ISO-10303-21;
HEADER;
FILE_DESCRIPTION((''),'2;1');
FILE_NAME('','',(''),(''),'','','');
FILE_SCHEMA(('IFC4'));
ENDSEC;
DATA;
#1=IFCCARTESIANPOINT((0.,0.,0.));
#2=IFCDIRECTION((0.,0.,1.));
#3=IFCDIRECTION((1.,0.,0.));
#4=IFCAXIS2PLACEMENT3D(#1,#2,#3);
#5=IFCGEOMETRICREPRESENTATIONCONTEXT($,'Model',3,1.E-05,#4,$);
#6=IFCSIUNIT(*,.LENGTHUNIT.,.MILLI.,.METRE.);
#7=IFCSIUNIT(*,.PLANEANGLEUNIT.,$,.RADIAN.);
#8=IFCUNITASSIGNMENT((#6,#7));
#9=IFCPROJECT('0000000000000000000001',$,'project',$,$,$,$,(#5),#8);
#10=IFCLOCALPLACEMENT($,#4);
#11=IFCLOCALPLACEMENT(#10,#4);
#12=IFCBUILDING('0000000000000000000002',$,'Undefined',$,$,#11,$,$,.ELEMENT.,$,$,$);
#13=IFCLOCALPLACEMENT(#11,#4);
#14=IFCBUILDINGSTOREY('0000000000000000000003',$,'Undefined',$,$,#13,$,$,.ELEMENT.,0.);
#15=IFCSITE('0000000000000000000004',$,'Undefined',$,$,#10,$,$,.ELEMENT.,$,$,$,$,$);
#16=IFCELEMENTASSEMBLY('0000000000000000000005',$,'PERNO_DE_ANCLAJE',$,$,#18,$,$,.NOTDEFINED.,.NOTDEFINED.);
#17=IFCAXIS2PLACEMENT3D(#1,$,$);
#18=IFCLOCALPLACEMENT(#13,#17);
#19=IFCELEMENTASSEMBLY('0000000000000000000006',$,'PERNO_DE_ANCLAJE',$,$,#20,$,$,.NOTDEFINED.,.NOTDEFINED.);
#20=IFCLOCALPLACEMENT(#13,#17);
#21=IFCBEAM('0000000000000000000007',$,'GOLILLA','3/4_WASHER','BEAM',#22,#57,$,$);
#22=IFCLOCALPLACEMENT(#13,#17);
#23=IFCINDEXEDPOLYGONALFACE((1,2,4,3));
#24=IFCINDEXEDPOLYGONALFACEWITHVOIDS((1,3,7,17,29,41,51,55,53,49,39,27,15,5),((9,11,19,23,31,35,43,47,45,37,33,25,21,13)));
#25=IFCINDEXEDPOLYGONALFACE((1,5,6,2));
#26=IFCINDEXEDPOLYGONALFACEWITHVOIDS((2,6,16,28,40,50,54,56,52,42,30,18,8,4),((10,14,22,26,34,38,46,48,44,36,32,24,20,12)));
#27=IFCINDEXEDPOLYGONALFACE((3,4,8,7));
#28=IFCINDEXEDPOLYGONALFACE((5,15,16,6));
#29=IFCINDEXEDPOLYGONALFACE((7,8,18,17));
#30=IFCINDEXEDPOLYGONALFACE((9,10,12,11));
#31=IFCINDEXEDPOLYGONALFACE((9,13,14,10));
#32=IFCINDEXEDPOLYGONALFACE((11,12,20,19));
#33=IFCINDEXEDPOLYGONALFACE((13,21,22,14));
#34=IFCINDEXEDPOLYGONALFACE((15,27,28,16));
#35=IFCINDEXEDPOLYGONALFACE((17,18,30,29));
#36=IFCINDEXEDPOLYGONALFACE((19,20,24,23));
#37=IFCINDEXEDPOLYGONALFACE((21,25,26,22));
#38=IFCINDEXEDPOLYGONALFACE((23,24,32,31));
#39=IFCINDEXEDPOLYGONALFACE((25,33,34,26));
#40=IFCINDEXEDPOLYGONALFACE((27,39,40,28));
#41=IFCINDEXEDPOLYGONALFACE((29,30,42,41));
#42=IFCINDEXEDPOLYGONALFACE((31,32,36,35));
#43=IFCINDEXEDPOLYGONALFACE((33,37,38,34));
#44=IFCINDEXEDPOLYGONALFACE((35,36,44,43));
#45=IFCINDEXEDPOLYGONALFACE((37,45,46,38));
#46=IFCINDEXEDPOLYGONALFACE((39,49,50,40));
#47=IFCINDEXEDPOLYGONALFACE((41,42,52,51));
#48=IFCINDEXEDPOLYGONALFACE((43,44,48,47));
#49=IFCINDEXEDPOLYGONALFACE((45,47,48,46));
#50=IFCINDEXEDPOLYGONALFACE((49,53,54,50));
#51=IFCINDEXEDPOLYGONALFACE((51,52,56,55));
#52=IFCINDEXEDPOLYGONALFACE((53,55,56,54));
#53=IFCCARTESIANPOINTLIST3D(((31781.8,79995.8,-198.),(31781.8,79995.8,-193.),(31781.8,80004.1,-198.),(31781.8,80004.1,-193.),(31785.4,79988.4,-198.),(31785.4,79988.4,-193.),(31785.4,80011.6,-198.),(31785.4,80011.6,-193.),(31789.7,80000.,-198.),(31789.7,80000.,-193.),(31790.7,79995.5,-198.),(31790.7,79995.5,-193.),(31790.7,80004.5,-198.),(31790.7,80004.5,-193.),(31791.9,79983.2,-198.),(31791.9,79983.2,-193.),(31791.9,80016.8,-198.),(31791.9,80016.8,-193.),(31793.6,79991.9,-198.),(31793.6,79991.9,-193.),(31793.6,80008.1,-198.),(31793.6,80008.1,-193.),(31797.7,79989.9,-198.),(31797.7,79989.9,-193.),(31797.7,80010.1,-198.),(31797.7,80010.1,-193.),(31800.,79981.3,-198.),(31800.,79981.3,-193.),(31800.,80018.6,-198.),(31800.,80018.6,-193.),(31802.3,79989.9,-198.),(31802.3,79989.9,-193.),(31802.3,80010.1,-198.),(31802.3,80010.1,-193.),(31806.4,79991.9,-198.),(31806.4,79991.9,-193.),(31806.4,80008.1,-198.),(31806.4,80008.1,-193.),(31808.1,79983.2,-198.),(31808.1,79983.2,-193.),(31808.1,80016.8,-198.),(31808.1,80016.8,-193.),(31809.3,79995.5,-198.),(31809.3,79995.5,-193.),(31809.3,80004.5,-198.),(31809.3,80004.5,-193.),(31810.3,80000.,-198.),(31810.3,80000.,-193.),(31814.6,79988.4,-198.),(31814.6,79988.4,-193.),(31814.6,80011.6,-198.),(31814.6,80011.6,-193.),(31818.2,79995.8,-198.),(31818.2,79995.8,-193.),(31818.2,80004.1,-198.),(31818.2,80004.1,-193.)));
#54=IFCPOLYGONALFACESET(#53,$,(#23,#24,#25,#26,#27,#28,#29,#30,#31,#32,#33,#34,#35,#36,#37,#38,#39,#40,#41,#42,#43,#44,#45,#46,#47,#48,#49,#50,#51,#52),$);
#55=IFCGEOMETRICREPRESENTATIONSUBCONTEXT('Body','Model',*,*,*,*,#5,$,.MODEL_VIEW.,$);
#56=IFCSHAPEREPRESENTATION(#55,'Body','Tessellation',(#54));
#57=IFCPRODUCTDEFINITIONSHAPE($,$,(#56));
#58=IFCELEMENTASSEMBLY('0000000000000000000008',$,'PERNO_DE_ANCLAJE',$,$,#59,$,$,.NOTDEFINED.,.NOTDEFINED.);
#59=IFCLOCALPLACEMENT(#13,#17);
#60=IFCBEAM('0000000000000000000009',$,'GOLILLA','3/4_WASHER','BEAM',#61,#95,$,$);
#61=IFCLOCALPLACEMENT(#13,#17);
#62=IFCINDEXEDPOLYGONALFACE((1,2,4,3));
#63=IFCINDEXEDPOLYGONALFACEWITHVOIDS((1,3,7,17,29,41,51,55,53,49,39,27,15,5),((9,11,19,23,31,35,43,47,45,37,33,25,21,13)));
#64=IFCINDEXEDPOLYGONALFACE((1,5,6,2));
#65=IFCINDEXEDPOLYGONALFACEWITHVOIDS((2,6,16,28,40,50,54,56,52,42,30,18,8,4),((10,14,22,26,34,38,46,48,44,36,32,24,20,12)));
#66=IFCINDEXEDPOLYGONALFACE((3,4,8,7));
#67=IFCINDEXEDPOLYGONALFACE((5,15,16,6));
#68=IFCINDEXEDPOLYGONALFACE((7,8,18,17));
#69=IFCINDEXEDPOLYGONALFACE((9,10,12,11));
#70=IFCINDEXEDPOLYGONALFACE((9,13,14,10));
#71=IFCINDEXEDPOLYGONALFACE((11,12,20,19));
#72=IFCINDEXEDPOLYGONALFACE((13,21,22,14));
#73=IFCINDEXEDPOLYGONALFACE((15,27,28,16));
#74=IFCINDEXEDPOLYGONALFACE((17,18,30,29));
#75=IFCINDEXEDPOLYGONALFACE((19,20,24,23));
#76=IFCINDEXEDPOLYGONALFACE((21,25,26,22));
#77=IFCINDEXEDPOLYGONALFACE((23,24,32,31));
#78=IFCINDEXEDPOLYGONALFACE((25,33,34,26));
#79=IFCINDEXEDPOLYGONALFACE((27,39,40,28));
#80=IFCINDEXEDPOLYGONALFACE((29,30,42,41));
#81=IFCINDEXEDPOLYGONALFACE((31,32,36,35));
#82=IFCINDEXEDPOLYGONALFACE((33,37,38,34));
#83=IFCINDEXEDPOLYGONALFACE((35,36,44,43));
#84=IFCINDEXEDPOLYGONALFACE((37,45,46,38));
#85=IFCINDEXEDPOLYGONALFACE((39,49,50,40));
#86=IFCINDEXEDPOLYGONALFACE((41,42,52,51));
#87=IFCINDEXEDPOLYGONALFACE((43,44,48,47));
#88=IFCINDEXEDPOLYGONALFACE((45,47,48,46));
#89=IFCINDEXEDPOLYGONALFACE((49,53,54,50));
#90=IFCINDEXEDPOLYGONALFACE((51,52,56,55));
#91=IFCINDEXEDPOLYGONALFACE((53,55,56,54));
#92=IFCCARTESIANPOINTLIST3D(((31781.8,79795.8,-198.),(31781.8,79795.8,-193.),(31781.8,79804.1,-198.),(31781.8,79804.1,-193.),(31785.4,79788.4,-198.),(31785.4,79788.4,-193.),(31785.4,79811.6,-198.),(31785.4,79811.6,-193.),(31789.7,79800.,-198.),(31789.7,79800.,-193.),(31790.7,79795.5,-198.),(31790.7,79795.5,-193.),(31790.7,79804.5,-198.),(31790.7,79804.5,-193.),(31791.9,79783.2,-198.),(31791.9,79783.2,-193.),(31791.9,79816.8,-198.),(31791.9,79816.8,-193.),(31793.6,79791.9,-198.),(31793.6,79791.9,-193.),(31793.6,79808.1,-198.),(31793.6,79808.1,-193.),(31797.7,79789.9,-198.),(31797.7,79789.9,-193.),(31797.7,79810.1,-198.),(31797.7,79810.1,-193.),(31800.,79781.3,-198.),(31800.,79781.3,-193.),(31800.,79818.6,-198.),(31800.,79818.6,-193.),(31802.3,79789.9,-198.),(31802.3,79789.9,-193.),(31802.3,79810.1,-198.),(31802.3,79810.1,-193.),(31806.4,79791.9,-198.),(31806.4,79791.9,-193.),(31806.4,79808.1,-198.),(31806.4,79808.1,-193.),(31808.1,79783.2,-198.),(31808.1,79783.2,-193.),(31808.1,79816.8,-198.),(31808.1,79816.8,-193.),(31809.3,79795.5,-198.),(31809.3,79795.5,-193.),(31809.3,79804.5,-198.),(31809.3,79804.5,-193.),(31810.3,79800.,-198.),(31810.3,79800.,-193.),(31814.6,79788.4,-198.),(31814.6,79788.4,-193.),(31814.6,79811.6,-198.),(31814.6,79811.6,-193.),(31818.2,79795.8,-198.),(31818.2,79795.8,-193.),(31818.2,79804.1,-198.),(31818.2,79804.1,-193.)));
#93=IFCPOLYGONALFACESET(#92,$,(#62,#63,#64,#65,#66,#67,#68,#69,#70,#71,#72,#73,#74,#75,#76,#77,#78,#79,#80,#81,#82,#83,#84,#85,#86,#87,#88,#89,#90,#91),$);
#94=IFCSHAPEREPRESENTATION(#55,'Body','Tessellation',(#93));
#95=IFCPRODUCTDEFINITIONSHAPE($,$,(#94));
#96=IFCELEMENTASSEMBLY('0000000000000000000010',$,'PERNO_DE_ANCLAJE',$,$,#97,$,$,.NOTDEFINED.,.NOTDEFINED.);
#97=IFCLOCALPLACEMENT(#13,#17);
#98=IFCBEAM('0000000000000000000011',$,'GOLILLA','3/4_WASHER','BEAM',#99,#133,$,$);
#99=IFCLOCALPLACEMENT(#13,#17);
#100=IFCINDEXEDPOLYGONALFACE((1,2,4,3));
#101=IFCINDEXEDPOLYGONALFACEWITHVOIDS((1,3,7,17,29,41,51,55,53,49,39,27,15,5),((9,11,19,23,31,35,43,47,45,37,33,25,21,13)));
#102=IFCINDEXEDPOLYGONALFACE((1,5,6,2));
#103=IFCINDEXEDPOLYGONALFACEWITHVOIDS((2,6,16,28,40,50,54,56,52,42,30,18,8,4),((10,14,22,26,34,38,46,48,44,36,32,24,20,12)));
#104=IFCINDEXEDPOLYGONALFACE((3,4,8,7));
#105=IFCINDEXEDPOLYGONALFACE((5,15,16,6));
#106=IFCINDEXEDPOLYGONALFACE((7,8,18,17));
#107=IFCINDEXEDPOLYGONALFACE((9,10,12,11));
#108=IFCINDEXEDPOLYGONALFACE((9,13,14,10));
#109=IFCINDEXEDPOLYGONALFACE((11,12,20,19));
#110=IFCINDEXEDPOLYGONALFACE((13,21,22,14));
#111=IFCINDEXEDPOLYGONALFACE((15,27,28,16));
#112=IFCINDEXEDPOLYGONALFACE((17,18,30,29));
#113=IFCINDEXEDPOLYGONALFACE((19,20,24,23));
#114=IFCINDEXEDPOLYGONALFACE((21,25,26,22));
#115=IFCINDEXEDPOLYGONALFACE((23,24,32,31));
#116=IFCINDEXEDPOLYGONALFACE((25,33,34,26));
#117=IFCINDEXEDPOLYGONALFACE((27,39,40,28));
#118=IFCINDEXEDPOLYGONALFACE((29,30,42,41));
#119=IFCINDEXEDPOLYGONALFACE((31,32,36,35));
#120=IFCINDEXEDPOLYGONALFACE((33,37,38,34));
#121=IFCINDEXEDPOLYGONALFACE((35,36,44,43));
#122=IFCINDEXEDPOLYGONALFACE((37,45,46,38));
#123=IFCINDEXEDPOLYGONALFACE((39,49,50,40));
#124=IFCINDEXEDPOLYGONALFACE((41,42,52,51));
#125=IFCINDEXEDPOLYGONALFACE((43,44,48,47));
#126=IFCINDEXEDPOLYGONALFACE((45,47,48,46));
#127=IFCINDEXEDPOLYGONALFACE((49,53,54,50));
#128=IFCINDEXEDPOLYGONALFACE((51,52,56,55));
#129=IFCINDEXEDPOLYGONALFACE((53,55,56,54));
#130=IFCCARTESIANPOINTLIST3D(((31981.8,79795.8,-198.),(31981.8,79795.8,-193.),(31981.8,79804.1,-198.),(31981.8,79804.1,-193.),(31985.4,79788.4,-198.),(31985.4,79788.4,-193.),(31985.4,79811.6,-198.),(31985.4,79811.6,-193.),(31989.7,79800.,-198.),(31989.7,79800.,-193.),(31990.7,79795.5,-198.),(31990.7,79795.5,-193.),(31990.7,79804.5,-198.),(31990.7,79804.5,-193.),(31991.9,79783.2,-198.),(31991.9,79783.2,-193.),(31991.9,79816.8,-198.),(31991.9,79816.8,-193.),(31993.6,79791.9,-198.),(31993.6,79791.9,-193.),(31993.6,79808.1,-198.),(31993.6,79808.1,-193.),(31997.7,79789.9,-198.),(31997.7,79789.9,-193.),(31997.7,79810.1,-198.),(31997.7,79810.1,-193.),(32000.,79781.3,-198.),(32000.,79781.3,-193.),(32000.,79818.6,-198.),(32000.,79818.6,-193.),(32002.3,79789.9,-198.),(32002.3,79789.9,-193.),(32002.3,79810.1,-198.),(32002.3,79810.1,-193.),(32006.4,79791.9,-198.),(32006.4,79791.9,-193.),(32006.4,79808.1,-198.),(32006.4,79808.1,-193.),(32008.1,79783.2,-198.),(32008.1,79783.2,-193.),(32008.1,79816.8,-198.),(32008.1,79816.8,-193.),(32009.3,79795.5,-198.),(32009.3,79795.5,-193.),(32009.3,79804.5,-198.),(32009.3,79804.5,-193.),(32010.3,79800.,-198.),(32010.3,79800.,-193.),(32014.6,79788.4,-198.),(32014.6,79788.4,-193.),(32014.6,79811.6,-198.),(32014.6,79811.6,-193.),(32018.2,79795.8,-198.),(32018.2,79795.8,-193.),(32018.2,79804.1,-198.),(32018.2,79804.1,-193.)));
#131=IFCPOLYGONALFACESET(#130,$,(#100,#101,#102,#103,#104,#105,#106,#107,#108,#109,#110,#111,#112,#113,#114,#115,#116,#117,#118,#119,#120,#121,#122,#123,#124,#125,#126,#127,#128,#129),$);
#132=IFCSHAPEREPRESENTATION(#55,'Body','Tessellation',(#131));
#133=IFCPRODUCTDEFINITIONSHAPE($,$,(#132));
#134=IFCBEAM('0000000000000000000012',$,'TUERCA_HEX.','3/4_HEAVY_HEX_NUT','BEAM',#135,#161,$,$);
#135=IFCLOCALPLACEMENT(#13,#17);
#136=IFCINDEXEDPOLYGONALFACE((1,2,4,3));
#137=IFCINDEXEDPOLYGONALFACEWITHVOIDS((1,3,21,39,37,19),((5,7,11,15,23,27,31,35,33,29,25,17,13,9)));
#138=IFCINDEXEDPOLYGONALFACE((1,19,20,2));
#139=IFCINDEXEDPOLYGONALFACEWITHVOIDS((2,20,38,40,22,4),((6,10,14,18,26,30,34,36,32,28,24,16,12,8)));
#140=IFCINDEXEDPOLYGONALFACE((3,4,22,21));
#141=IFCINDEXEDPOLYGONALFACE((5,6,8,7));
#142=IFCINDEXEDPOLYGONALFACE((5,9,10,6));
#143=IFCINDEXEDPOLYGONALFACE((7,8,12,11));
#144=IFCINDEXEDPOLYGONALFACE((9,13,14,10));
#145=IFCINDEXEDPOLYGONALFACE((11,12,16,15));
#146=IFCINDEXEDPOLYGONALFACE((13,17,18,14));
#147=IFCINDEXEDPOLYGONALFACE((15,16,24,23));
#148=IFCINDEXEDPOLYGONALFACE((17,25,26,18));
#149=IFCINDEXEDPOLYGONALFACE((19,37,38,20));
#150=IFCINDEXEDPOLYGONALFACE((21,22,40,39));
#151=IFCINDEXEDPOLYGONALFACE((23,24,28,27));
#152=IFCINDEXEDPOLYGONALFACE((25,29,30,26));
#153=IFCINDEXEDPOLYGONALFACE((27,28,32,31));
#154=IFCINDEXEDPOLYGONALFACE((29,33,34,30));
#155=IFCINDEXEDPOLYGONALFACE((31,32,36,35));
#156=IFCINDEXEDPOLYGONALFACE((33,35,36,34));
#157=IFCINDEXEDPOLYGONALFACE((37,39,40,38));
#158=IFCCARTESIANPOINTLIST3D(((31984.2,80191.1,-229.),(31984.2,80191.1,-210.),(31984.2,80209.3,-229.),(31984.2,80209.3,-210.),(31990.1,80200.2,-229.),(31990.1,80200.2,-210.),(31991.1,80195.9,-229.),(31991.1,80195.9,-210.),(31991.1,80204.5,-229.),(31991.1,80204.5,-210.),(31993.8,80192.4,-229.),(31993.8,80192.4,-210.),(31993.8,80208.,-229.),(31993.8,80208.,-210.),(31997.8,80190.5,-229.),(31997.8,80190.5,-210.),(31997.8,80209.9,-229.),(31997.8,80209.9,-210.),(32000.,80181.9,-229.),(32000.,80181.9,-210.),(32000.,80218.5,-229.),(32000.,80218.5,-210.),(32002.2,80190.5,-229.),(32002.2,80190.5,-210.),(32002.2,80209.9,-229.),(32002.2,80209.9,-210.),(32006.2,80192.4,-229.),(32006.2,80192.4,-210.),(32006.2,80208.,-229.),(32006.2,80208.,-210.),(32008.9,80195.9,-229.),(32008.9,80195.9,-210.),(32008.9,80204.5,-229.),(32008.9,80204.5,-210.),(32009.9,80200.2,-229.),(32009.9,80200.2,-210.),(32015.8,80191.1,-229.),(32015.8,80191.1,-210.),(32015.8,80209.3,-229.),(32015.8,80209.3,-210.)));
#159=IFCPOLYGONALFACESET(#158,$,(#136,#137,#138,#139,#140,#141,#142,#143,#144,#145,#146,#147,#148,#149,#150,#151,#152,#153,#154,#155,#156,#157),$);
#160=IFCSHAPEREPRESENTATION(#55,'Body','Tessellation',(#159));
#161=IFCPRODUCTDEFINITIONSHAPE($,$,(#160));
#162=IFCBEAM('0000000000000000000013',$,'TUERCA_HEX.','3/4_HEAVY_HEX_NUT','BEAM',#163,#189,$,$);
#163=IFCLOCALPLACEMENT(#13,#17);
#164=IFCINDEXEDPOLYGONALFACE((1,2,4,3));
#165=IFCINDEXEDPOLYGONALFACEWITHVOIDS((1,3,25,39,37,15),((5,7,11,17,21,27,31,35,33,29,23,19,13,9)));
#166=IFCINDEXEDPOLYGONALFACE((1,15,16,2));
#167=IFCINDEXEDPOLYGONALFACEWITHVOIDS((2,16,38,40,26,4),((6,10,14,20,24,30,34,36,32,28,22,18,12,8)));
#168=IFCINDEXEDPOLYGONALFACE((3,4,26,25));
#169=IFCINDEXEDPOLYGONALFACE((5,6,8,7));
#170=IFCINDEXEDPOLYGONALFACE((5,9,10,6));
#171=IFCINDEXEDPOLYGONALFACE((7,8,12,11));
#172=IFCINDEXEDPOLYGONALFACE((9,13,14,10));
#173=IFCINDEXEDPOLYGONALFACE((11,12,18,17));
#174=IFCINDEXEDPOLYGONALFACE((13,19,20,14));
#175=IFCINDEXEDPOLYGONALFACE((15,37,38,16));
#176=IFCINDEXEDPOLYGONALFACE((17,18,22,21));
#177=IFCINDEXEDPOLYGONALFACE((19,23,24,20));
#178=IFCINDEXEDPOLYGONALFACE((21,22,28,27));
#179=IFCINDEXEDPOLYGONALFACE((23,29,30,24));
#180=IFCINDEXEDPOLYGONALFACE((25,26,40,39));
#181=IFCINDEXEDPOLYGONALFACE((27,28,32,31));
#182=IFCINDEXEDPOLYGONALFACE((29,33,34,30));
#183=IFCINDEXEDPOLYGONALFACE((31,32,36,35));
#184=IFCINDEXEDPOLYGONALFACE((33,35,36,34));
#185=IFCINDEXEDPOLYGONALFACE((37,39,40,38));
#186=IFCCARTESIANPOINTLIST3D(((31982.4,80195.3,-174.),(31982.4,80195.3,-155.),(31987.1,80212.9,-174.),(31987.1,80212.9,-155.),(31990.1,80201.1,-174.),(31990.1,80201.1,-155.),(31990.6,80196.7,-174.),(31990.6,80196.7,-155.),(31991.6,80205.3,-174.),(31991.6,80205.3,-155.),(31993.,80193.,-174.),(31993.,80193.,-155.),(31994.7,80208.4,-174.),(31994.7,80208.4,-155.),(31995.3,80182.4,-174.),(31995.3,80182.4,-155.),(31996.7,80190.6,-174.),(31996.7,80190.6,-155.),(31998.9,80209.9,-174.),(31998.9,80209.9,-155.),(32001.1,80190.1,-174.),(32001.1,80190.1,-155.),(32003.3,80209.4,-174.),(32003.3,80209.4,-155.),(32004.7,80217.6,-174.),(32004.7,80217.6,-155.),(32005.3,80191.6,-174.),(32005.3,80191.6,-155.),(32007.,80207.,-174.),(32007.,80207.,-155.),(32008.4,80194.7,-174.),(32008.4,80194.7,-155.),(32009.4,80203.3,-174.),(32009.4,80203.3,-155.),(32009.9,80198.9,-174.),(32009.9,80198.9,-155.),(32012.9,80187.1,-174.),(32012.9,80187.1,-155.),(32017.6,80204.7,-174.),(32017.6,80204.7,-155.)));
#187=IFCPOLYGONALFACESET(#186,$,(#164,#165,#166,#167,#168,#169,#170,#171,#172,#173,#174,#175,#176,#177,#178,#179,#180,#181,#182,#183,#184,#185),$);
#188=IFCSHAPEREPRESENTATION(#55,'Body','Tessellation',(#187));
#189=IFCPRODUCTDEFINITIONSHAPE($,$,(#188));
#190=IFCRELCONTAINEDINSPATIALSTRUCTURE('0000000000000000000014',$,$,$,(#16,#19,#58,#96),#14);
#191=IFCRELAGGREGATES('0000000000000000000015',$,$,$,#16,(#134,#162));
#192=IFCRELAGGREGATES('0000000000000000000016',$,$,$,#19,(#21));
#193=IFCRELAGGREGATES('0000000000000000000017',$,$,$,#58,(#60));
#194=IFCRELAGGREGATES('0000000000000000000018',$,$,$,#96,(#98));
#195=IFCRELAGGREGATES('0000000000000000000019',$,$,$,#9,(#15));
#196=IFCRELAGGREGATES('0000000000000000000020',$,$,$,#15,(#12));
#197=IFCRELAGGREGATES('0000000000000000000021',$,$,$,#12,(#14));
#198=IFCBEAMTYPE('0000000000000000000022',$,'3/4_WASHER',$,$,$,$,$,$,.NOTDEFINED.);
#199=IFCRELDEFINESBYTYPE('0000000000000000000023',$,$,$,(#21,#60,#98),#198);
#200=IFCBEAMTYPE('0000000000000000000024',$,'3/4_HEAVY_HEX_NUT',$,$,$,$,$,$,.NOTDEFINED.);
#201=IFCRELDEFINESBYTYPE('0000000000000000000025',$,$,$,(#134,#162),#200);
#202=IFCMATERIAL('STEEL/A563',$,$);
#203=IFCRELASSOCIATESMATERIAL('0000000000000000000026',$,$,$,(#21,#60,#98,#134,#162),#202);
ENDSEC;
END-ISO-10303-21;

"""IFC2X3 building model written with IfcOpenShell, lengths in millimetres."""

from ifc_helpers import new_model, si_unit, frame, origin_with_axes, place, context, subcontext, project, spatial, polyline, outline, extrude, material, type_object, element, aggregate, save


model = new_model("IFC2X3")

# Units and contexts
model_context = context("Model", 3, precision=1e-05, world=origin_with_axes())
body_context = subcontext(model_context, "Body", "Model", "MODEL_VIEW")
ifc_project = project(units=[si_unit("LENGTHUNIT", "METRE", prefix="MILLI"), si_unit("PLANEANGLEUNIT", "RADIAN")], contexts=[model_context])

# Site, building, storey
site_placement = place(None, origin_with_axes())
site = spatial("IfcSite", under=ifc_project, at=site_placement, Name="Undefined", CompositionType="ELEMENT")
building_placement = place(site_placement, origin_with_axes())
building = spatial("IfcBuilding", under=site, at=building_placement, Name="Undefined", CompositionType="ELEMENT")
storey_placement = place(building_placement, origin_with_axes())
storey = spatial("IfcBuildingStorey", under=building, at=storey_placement, Name="Undefined", CompositionType="ELEMENT", Elevation=0.0)

# Element assemblies, beams
assembly_1_placement = place(storey_placement, origin_with_axes())
assembly_1 = element("IfcElementAssembly", 1, at=assembly_1_placement, inside=storey, Name="PERNO_DE_ANCLAJE", AssemblyPlace="NOTDEFINED", PredefinedType="NOTDEFINED")
ifc_material_1 = material(Name="STEEL/A563")
beam_type_1 = type_object("IfcBeamType", Name="3/4_WASHER", PredefinedType="NOTDEFINED")
assembly_2_placement = place(storey_placement, origin_with_axes())
assembly_2 = element("IfcElementAssembly", 2, at=assembly_2_placement, inside=storey, Name="PERNO_DE_ANCLAJE", AssemblyPlace="NOTDEFINED", PredefinedType="NOTDEFINED")
beam_1_placement = place(assembly_2_placement, frame((31800.0, 80000.0, -193.0), z_axis=(1.0, 0.0, 0.0), x_axis=(0.0, 0.00008, -1.0)))
beam_1 = element("IfcBeam", 3, at=beam_1_placement, type_object=beam_type_1, material=ifc_material_1, Name="GOLILLA", Description="3/4_WASHER", ObjectType="BEAM", context=body_context, shape_type="SweptSolid", body=[
    extrude(outline(polyline([(-16.8, 8.1), (-11.6, 14.6), (-4.2, 18.2), (4.2, 18.2), (11.6, 14.6), (16.8, 8.1), (18.6, 0.0), (16.8, -8.1), (11.6, -14.6), (4.2, -18.2), (-4.2, -18.2), (-11.6, -14.6), (-16.8, -8.1), (-18.6, 0.0), (-16.8, 8.1)]), holes=[polyline([(8.1, 6.4), (4.5, 9.3), (0.0, 10.3), (-4.5, 9.3), (-8.1, 6.4), (-10.1, 2.3), (-10.1, -2.3), (-8.1, -6.4), (-4.5, -9.3), (0.0, -10.3), (4.5, -9.3), (8.1, -6.4), (10.1, -2.3), (10.1, 2.3), (8.1, 6.4)])]), frame((5.0, 0.0, 0.0), z_axis=(-1.0, 0.0, 0.0), x_axis=(0.0, -1.0, 0.0)), (0.0, 0.0, 1.0), 5.0),
])
assembly_3_placement = place(storey_placement, origin_with_axes())
assembly_3 = element("IfcElementAssembly", 4, at=assembly_3_placement, inside=storey, Name="PERNO_DE_ANCLAJE", AssemblyPlace="NOTDEFINED", PredefinedType="NOTDEFINED")
beam_2_placement = place(assembly_3_placement, frame((31800.0, 79800.0, -193.0), z_axis=(1.0, 0.0, 0.0), x_axis=(0.0, 0.00008, -1.0)))
beam_2 = element("IfcBeam", 5, at=beam_2_placement, type_object=beam_type_1, material=ifc_material_1, Name="GOLILLA", Description="3/4_WASHER", ObjectType="BEAM", context=body_context, shape_type="SweptSolid", body=[
    extrude(outline(polyline([(-16.8, 8.1), (-11.6, 14.6), (-4.2, 18.2), (4.2, 18.2), (11.6, 14.6), (16.8, 8.1), (18.6, 0.0), (16.8, -8.1), (11.6, -14.6), (4.2, -18.2), (-4.2, -18.2), (-11.6, -14.6), (-16.8, -8.1), (-18.6, 0.0), (-16.8, 8.1)]), holes=[polyline([(8.1, 6.4), (4.5, 9.3), (0.0, 10.3), (-4.5, 9.3), (-8.1, 6.4), (-10.1, 2.3), (-10.1, -2.3), (-8.1, -6.4), (-4.5, -9.3), (0.0, -10.3), (4.5, -9.3), (8.1, -6.4), (10.1, -2.3), (10.1, 2.3), (8.1, 6.4)])]), frame((5.0, 0.0, 0.0), z_axis=(-1.0, 0.0, 0.0), x_axis=(0.0, -1.0, 0.0)), (0.0, 0.0, 1.0), 5.0),
])
assembly_4_placement = place(storey_placement, origin_with_axes())
assembly_4 = element("IfcElementAssembly", 6, at=assembly_4_placement, inside=storey, Name="PERNO_DE_ANCLAJE", AssemblyPlace="NOTDEFINED", PredefinedType="NOTDEFINED")
beam_3_placement = place(assembly_4_placement, frame((32000.0, 79800.0, -193.0), z_axis=(1.0, 0.0, 0.0), x_axis=(0.0, 0.00008, -1.0)))
beam_3 = element("IfcBeam", 7, at=beam_3_placement, type_object=beam_type_1, material=ifc_material_1, Name="GOLILLA", Description="3/4_WASHER", ObjectType="BEAM", context=body_context, shape_type="SweptSolid", body=[
    extrude(outline(polyline([(-16.8, 8.1), (-11.6, 14.6), (-4.2, 18.2), (4.2, 18.2), (11.6, 14.6), (16.8, 8.1), (18.6, 0.0), (16.8, -8.1), (11.6, -14.6), (4.2, -18.2), (-4.2, -18.2), (-11.6, -14.6), (-16.8, -8.1), (-18.6, 0.0), (-16.8, 8.1)]), holes=[polyline([(8.1, 6.4), (4.5, 9.3), (0.0, 10.3), (-4.5, 9.3), (-8.1, 6.4), (-10.1, 2.3), (-10.1, -2.3), (-8.1, -6.4), (-4.5, -9.3), (0.0, -10.3), (4.5, -9.3), (8.1, -6.4), (10.1, -2.3), (10.1, 2.3), (8.1, 6.4)])]), frame((5.0, 0.0, 0.0), z_axis=(-1.0, 0.0, 0.0), x_axis=(0.0, -1.0, 0.0)), (0.0, 0.0, 1.0), 5.0),
])

# Beams
beam_type_2 = type_object("IfcBeamType", Name="3/4_HEAVY_HEX_NUT", PredefinedType="NOTDEFINED")
beam_4_placement = place(assembly_1_placement, frame((32000.0, 80200.2, -210.0), z_axis=(1.0, 0.0, 0.0), x_axis=(0.0, 0.0, -1.0)))
beam_4 = element("IfcBeam", 8, at=beam_4_placement, type_object=beam_type_2, material=ifc_material_1, Name="TUERCA_HEX.", Description="3/4_HEAVY_HEX_NUT", ObjectType="BEAM", context=body_context, shape_type="SweptSolid", body=[
    extrude(outline(polyline([(-9.1, -15.8), (-18.3, 0.0), (-9.1, 15.8), (9.1, 15.8), (18.3, 0.0), (9.1, -15.8), (-9.1, -15.8)]), holes=[polyline([(7.8, 6.2), (4.3, 8.9), (0.0, 9.9), (-4.3, 8.9), (-7.8, 6.2), (-9.7, 2.2), (-9.7, -2.2), (-7.8, -6.2), (-4.3, -8.9), (0.0, -9.9), (4.3, -8.9), (7.8, -6.2), (9.7, -2.2), (9.7, 2.2), (7.8, 6.2)])]), frame((19.0, 0.0, 0.0), z_axis=(-1.0, 0.0, 0.0), x_axis=(0.0, -1.0, 0.0)), (0.0, 0.0, 1.0), 19.0),
])
beam_5_placement = place(assembly_1_placement, frame((32000.0, 80200.0, -155.0), z_axis=(0.707107, 0.707107, 0.0), x_axis=(0.0, 0.0, -1.0)))
beam_5 = element("IfcBeam", 9, at=beam_5_placement, type_object=beam_type_2, material=ifc_material_1, Name="TUERCA_HEX.", Description="3/4_HEAVY_HEX_NUT", ObjectType="BEAM", context=body_context, shape_type="SweptSolid", body=[
    extrude(outline(polyline([(-9.1, -15.8), (-18.3, 0.0), (-9.1, 15.8), (9.1, 15.8), (18.3, 0.0), (9.1, -15.8), (-9.1, -15.8)]), holes=[polyline([(7.8, 6.2), (4.3, 8.9), (0.0, 9.9), (-4.3, 8.9), (-7.8, 6.2), (-9.7, 2.2), (-9.7, -2.2), (-7.8, -6.2), (-4.3, -8.9), (0.0, -9.9), (4.3, -8.9), (7.8, -6.2), (9.7, -2.2), (9.7, 2.2), (7.8, 6.2)])]), frame((19.0, 0.0, 0.0), z_axis=(-1.0, 0.0, 0.0), x_axis=(0.0, -1.0, 0.0)), (0.0, 0.0, 1.0), 19.0),
])
aggregate(assembly_1, [beam_4, beam_5])
aggregate(assembly_2, [beam_1])
aggregate(assembly_3, [beam_2])
aggregate(assembly_4, [beam_3])

save(model, "model.ifc")
